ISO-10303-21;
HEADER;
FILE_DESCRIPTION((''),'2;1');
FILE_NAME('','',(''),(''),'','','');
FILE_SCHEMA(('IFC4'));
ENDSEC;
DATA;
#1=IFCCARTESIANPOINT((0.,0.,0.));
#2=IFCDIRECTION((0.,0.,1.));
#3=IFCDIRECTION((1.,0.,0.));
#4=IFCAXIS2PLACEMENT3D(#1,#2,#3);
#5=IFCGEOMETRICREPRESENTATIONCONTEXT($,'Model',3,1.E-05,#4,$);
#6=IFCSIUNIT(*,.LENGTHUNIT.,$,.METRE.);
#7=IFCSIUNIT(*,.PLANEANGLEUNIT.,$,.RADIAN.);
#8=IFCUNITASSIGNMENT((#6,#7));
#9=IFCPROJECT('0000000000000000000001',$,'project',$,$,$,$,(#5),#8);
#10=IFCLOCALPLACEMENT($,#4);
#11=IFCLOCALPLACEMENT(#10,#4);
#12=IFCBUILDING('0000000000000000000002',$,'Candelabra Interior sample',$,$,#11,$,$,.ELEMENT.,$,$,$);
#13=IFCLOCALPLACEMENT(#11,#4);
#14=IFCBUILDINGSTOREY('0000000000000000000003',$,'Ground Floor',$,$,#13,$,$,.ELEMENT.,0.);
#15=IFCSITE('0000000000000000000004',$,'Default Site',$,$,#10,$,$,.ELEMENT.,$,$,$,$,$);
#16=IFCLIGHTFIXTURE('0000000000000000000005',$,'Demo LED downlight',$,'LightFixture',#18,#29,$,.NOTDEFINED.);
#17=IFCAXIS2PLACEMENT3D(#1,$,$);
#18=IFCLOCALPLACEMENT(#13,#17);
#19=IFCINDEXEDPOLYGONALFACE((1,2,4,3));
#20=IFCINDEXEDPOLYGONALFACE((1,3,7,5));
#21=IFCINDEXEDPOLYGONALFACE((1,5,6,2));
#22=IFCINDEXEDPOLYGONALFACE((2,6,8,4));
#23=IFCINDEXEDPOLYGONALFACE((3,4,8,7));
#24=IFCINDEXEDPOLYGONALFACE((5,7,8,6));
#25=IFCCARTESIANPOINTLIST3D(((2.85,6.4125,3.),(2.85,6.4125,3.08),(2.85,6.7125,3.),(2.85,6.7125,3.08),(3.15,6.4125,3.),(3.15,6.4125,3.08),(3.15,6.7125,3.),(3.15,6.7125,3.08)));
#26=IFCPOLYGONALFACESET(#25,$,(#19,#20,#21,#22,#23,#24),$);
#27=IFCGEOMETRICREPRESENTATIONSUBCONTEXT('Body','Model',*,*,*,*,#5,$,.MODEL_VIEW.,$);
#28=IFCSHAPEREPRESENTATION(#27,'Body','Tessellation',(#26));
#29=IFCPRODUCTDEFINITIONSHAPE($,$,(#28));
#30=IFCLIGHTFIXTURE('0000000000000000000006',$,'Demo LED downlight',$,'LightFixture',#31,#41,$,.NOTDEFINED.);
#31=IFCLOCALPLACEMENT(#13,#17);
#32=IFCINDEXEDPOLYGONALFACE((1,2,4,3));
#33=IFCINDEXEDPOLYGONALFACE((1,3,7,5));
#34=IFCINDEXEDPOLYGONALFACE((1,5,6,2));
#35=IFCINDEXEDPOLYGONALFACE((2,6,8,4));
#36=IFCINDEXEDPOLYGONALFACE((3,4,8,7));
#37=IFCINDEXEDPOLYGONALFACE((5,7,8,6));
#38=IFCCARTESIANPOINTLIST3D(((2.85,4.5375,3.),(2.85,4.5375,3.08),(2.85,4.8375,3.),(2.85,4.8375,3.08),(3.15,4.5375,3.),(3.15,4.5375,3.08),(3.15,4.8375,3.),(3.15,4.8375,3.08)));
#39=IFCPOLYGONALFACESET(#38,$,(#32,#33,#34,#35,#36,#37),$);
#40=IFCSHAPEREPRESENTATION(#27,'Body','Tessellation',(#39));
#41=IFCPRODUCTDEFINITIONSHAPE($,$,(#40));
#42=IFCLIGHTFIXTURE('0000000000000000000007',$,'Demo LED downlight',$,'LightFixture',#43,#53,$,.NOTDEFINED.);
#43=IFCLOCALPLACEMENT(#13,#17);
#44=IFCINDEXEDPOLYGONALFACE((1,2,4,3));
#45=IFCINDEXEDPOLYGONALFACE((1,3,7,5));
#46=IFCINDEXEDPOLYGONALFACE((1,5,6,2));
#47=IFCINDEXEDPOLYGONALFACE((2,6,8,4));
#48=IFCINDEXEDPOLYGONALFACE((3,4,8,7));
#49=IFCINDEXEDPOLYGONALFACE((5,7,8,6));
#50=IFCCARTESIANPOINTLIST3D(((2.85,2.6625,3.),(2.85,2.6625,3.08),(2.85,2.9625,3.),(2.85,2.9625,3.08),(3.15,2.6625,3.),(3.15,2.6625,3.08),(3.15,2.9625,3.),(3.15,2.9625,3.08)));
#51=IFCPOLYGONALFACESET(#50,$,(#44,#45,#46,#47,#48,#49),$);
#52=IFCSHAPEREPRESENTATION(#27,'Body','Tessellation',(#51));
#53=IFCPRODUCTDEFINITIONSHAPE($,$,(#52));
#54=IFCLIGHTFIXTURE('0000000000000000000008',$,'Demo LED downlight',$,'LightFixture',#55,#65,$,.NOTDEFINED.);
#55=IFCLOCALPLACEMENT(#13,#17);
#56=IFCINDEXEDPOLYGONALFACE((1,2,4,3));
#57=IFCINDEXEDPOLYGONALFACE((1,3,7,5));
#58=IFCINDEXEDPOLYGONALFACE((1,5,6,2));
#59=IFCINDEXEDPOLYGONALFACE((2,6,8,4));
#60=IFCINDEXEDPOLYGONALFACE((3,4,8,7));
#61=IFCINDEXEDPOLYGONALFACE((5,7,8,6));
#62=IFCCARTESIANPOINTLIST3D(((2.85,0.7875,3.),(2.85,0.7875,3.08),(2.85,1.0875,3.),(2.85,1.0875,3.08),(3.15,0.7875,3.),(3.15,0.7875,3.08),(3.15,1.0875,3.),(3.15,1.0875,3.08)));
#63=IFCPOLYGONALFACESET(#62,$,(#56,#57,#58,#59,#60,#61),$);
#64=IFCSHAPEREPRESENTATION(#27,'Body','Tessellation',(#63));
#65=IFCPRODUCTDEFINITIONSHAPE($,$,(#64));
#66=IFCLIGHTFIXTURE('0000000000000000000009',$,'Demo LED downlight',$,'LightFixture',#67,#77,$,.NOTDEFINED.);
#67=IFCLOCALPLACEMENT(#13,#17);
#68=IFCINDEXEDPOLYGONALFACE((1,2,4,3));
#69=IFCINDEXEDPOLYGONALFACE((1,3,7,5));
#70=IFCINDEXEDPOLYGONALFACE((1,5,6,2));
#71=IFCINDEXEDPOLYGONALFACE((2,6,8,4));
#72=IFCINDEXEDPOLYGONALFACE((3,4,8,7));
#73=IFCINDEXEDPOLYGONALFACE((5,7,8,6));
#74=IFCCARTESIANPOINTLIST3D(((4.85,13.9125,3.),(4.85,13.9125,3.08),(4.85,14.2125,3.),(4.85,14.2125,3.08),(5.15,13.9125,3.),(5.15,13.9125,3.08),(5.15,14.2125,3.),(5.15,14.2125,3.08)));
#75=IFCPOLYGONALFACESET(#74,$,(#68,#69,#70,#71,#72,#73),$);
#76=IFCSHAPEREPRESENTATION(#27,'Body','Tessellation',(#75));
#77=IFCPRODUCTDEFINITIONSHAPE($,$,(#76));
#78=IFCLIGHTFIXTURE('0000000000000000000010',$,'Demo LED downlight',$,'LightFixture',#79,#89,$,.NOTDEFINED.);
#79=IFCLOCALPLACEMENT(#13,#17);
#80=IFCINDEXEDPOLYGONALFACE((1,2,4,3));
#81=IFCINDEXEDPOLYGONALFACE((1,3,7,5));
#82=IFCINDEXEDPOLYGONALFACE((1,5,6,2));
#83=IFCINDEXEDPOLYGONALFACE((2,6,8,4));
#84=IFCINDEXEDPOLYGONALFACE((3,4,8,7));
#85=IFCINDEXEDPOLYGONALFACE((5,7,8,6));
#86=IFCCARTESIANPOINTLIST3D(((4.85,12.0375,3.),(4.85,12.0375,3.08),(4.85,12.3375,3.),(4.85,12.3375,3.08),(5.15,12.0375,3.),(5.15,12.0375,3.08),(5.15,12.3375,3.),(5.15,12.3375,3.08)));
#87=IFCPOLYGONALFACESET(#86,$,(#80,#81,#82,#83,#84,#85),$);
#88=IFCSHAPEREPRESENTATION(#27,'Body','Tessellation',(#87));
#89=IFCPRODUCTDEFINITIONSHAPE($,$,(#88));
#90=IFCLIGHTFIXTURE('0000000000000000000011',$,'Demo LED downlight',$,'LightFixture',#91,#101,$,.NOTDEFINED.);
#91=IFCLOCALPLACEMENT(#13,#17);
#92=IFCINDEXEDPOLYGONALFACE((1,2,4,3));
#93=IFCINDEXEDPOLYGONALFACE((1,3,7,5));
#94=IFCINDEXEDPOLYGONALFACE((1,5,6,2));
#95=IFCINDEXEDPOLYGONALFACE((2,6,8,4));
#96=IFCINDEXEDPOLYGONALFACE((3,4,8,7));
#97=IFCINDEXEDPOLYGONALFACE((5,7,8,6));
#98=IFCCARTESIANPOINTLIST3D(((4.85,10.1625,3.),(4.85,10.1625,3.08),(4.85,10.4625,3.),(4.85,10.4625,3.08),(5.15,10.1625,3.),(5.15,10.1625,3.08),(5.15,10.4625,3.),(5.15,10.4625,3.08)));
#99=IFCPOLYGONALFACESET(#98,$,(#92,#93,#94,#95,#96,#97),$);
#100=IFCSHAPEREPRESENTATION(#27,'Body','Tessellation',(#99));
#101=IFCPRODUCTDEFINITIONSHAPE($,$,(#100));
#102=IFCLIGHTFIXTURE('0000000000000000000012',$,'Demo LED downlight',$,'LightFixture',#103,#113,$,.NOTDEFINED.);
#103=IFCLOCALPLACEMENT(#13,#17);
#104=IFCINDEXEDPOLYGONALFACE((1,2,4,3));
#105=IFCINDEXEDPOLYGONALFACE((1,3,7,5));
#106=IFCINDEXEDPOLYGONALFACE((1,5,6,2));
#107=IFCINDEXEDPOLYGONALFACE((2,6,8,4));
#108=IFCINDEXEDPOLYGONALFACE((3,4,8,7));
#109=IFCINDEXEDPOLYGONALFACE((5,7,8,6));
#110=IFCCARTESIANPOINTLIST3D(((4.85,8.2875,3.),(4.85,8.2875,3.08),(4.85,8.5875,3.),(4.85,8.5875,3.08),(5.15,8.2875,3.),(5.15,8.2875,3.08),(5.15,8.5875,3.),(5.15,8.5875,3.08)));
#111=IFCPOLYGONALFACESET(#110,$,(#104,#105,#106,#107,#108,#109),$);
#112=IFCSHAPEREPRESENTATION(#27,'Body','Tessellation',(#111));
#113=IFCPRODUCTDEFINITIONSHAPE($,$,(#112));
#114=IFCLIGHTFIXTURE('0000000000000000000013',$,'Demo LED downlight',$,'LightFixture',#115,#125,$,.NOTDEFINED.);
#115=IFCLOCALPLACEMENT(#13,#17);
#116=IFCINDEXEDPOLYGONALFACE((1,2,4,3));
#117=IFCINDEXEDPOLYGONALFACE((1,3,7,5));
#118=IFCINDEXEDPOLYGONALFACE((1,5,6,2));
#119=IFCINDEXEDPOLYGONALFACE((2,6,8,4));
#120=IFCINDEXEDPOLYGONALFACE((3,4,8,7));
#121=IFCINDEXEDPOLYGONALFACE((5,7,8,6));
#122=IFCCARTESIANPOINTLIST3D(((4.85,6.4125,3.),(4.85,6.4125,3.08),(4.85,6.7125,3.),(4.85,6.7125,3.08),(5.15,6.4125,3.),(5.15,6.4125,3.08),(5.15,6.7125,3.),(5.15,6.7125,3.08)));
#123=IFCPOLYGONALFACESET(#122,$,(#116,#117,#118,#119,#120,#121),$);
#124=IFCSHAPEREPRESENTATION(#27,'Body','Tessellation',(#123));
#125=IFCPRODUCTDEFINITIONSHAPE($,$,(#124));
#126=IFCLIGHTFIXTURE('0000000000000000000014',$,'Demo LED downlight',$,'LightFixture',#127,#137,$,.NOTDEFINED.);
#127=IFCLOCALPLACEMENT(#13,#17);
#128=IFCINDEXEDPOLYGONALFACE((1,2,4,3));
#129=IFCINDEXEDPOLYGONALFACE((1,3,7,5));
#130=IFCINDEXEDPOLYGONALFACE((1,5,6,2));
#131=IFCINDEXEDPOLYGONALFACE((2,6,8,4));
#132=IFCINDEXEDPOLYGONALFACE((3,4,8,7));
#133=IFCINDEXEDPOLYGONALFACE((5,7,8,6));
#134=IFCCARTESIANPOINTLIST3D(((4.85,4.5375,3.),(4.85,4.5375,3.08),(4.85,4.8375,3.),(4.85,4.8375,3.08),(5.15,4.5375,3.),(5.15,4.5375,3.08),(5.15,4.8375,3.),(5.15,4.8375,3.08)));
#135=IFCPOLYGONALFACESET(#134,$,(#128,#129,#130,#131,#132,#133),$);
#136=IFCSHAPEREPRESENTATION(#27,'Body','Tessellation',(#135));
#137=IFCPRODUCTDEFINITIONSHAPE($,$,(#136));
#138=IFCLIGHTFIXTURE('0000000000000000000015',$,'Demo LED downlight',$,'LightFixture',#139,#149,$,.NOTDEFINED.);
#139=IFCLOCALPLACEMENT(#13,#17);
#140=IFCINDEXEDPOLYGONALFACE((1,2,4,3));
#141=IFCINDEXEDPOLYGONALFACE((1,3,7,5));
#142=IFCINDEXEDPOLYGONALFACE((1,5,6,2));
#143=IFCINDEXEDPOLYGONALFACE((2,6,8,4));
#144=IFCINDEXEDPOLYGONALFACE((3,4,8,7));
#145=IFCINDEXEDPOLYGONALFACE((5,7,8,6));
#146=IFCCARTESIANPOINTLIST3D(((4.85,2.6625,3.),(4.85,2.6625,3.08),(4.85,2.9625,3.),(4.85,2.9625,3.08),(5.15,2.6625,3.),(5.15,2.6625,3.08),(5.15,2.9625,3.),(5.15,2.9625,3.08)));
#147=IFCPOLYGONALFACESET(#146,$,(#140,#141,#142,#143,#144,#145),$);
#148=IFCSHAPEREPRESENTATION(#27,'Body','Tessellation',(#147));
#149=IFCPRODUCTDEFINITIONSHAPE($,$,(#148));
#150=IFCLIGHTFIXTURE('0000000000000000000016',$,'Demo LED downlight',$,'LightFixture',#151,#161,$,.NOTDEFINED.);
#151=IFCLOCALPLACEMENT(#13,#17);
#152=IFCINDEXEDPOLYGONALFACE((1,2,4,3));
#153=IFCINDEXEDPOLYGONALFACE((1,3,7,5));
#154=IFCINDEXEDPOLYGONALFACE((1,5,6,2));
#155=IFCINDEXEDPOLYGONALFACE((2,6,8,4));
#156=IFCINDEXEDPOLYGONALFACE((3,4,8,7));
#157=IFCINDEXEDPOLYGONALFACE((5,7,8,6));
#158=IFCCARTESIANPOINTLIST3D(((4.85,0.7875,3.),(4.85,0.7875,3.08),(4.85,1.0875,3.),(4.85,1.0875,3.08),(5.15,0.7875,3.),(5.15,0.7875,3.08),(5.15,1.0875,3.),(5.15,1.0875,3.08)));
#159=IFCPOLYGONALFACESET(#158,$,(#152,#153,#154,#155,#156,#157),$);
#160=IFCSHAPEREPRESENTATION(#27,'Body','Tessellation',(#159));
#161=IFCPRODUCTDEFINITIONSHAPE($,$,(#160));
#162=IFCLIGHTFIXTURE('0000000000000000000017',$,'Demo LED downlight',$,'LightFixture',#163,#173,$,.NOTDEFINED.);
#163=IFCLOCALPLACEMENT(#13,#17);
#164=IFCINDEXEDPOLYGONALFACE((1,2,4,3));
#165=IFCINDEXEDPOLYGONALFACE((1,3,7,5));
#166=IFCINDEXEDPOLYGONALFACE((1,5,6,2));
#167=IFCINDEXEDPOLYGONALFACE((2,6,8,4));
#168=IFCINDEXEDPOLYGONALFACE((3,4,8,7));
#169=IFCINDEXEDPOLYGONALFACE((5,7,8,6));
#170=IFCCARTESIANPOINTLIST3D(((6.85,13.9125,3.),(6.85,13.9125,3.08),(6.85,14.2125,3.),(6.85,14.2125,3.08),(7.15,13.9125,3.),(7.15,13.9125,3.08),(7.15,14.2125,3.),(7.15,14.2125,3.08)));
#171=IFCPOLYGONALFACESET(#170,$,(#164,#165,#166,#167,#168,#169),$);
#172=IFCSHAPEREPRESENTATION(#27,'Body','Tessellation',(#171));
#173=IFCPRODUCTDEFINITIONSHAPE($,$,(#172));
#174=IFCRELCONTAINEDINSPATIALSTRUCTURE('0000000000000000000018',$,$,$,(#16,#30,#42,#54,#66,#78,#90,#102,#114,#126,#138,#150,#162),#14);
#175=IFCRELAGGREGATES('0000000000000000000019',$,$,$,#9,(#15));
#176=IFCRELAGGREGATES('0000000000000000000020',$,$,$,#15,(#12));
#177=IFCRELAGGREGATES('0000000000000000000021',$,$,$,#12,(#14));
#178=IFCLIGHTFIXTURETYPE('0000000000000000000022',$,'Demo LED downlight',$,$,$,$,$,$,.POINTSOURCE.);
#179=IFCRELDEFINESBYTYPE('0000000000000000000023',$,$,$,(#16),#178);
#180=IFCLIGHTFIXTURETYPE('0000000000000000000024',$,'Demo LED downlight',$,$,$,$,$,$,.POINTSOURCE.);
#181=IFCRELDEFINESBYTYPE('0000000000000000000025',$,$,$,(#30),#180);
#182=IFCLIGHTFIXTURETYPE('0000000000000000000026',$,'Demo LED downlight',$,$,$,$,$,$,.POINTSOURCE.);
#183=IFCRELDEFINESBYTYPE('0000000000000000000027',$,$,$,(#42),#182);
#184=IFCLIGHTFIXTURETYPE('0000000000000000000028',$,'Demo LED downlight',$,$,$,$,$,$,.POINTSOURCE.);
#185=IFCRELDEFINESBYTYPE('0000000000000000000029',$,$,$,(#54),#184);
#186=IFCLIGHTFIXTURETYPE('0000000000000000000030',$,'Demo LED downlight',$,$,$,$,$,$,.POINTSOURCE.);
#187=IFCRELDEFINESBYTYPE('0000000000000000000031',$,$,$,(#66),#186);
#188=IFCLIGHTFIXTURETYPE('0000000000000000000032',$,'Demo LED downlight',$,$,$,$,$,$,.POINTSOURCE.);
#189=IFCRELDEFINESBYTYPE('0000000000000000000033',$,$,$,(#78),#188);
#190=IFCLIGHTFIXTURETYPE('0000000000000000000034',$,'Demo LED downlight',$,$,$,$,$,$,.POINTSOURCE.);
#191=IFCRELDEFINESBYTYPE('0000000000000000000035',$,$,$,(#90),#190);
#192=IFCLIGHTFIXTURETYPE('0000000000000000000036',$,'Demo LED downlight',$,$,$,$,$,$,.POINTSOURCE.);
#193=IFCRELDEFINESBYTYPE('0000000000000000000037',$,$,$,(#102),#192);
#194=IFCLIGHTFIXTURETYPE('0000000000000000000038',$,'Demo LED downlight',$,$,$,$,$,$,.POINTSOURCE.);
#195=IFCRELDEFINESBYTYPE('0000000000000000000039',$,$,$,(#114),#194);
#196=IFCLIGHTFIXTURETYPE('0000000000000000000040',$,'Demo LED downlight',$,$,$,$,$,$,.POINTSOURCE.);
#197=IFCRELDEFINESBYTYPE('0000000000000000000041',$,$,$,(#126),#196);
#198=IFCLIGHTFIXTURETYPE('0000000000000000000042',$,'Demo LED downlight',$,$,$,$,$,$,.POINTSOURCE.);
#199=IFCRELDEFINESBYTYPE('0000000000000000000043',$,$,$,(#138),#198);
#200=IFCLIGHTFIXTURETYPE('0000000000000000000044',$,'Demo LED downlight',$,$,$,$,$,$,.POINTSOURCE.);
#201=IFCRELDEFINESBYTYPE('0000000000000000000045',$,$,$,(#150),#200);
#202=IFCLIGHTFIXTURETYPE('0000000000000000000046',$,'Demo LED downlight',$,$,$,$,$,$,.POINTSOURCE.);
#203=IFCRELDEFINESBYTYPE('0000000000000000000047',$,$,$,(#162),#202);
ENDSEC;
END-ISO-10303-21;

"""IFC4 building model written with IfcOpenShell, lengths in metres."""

from ifc_helpers import new_model, si_unit, frame, origin_with_axes, place, context, subcontext, project, spatial, polyline, outline, extrude, type_object, element, save


model = new_model("IFC4")

# Units and contexts
model_context = context("Model", 3, precision=1e-05, world=origin_with_axes())
body_context = subcontext(model_context, "Body", "Model", "MODEL_VIEW")
ifc_project = project(units=[si_unit("LENGTHUNIT", "METRE"), si_unit("PLANEANGLEUNIT", "RADIAN")], contexts=[model_context])

# Site, building, storey
site_placement = place(None, origin_with_axes())
site = spatial("IfcSite", under=ifc_project, at=site_placement, Name="Default Site", CompositionType="ELEMENT")
building_placement = place(site_placement, origin_with_axes())
building = spatial("IfcBuilding", under=site, at=building_placement, Name="Candelabra Interior sample", CompositionType="ELEMENT")
storey_placement = place(building_placement, origin_with_axes())
storey = spatial("IfcBuildingStorey", under=building, at=storey_placement, Name="Ground Floor", CompositionType="ELEMENT", Elevation=0.0)

# Light fixtures
light_fixture_type_1 = type_object("IfcLightFixtureType", Name="Demo LED downlight", PredefinedType="POINTSOURCE")
light_fixture_1_placement = place(storey_placement, frame((3.0, 6.5625, 3.08), z_axis=(0.0, 0.0, 1.0), x_axis=(1.0, 0.0, 0.0)))
element("IfcLightFixture", 1, at=light_fixture_1_placement, inside=storey, type_object=light_fixture_type_1, Name="Demo LED downlight", ObjectType="LightFixture", PredefinedType="NOTDEFINED", context=body_context, shape_type="SweptSolid", body=[
    extrude(outline(polyline([(0.15, 0.15), (-0.15, 0.15), (-0.15, -0.15), (0.15, -0.15), (0.15, 0.15)])), origin_with_axes(), (0.0, 0.0, -1.0), 0.08),
])
light_fixture_type_2 = type_object("IfcLightFixtureType", Name="Demo LED downlight", PredefinedType="POINTSOURCE")
light_fixture_2_placement = place(storey_placement, frame((3.0, 4.6875, 3.08), z_axis=(0.0, 0.0, 1.0), x_axis=(1.0, 0.0, 0.0)))
element("IfcLightFixture", 2, at=light_fixture_2_placement, inside=storey, type_object=light_fixture_type_2, Name="Demo LED downlight", ObjectType="LightFixture", PredefinedType="NOTDEFINED", context=body_context, shape_type="SweptSolid", body=[
    extrude(outline(polyline([(0.15, 0.15), (-0.15, 0.15), (-0.15, -0.15), (0.15, -0.15), (0.15, 0.15)])), origin_with_axes(), (0.0, 0.0, -1.0), 0.08),
])
light_fixture_type_3 = type_object("IfcLightFixtureType", Name="Demo LED downlight", PredefinedType="POINTSOURCE")
light_fixture_3_placement = place(storey_placement, frame((3.0, 2.8125, 3.08), z_axis=(0.0, 0.0, 1.0), x_axis=(1.0, 0.0, 0.0)))
element("IfcLightFixture", 3, at=light_fixture_3_placement, inside=storey, type_object=light_fixture_type_3, Name="Demo LED downlight", ObjectType="LightFixture", PredefinedType="NOTDEFINED", context=body_context, shape_type="SweptSolid", body=[
    extrude(outline(polyline([(0.15, 0.15), (-0.15, 0.15), (-0.15, -0.15), (0.15, -0.15), (0.15, 0.15)])), origin_with_axes(), (0.0, 0.0, -1.0), 0.08),
])
light_fixture_type_4 = type_object("IfcLightFixtureType", Name="Demo LED downlight", PredefinedType="POINTSOURCE")
light_fixture_4_placement = place(storey_placement, frame((3.0, 0.9375, 3.08), z_axis=(0.0, 0.0, 1.0), x_axis=(1.0, 0.0, 0.0)))
element("IfcLightFixture", 4, at=light_fixture_4_placement, inside=storey, type_object=light_fixture_type_4, Name="Demo LED downlight", ObjectType="LightFixture", PredefinedType="NOTDEFINED", context=body_context, shape_type="SweptSolid", body=[
    extrude(outline(polyline([(0.15, 0.15), (-0.15, 0.15), (-0.15, -0.15), (0.15, -0.15), (0.15, 0.15)])), origin_with_axes(), (0.0, 0.0, -1.0), 0.08),
])
light_fixture_type_5 = type_object("IfcLightFixtureType", Name="Demo LED downlight", PredefinedType="POINTSOURCE")
light_fixture_5_placement = place(storey_placement, frame((5.0, 14.0625, 3.08), z_axis=(0.0, 0.0, 1.0), x_axis=(1.0, 0.0, 0.0)))
element("IfcLightFixture", 5, at=light_fixture_5_placement, inside=storey, type_object=light_fixture_type_5, Name="Demo LED downlight", ObjectType="LightFixture", PredefinedType="NOTDEFINED", context=body_context, shape_type="SweptSolid", body=[
    extrude(outline(polyline([(0.15, 0.15), (-0.15, 0.15), (-0.15, -0.15), (0.15, -0.15), (0.15, 0.15)])), origin_with_axes(), (0.0, 0.0, -1.0), 0.08),
])
light_fixture_type_6 = type_object("IfcLightFixtureType", Name="Demo LED downlight", PredefinedType="POINTSOURCE")
light_fixture_6_placement = place(storey_placement, frame((5.0, 12.1875, 3.08), z_axis=(0.0, 0.0, 1.0), x_axis=(1.0, 0.0, 0.0)))
element("IfcLightFixture", 6, at=light_fixture_6_placement, inside=storey, type_object=light_fixture_type_6, Name="Demo LED downlight", ObjectType="LightFixture", PredefinedType="NOTDEFINED", context=body_context, shape_type="SweptSolid", body=[
    extrude(outline(polyline([(0.15, 0.15), (-0.15, 0.15), (-0.15, -0.15), (0.15, -0.15), (0.15, 0.15)])), origin_with_axes(), (0.0, 0.0, -1.0), 0.08),
])
light_fixture_type_7 = type_object("IfcLightFixtureType", Name="Demo LED downlight", PredefinedType="POINTSOURCE")
light_fixture_7_placement = place(storey_placement, frame((5.0, 10.3125, 3.08), z_axis=(0.0, 0.0, 1.0), x_axis=(1.0, 0.0, 0.0)))
element("IfcLightFixture", 7, at=light_fixture_7_placement, inside=storey, type_object=light_fixture_type_7, Name="Demo LED downlight", ObjectType="LightFixture", PredefinedType="NOTDEFINED", context=body_context, shape_type="SweptSolid", body=[
    extrude(outline(polyline([(0.15, 0.15), (-0.15, 0.15), (-0.15, -0.15), (0.15, -0.15), (0.15, 0.15)])), origin_with_axes(), (0.0, 0.0, -1.0), 0.08),
])
light_fixture_type_8 = type_object("IfcLightFixtureType", Name="Demo LED downlight", PredefinedType="POINTSOURCE")
light_fixture_8_placement = place(storey_placement, frame((5.0, 8.4375, 3.08), z_axis=(0.0, 0.0, 1.0), x_axis=(1.0, 0.0, 0.0)))
element("IfcLightFixture", 8, at=light_fixture_8_placement, inside=storey, type_object=light_fixture_type_8, Name="Demo LED downlight", ObjectType="LightFixture", PredefinedType="NOTDEFINED", context=body_context, shape_type="SweptSolid", body=[
    extrude(outline(polyline([(0.15, 0.15), (-0.15, 0.15), (-0.15, -0.15), (0.15, -0.15), (0.15, 0.15)])), origin_with_axes(), (0.0, 0.0, -1.0), 0.08),
])
light_fixture_type_9 = type_object("IfcLightFixtureType", Name="Demo LED downlight", PredefinedType="POINTSOURCE")
light_fixture_9_placement = place(storey_placement, frame((5.0, 6.5625, 3.08), z_axis=(0.0, 0.0, 1.0), x_axis=(1.0, 0.0, 0.0)))
element("IfcLightFixture", 9, at=light_fixture_9_placement, inside=storey, type_object=light_fixture_type_9, Name="Demo LED downlight", ObjectType="LightFixture", PredefinedType="NOTDEFINED", context=body_context, shape_type="SweptSolid", body=[
    extrude(outline(polyline([(0.15, 0.15), (-0.15, 0.15), (-0.15, -0.15), (0.15, -0.15), (0.15, 0.15)])), origin_with_axes(), (0.0, 0.0, -1.0), 0.08),
])
light_fixture_type_10 = type_object("IfcLightFixtureType", Name="Demo LED downlight", PredefinedType="POINTSOURCE")
light_fixture_10_placement = place(storey_placement, frame((5.0, 4.6875, 3.08), z_axis=(0.0, 0.0, 1.0), x_axis=(1.0, 0.0, 0.0)))
element("IfcLightFixture", 10, at=light_fixture_10_placement, inside=storey, type_object=light_fixture_type_10, Name="Demo LED downlight", ObjectType="LightFixture", PredefinedType="NOTDEFINED", context=body_context, shape_type="SweptSolid", body=[
    extrude(outline(polyline([(0.15, 0.15), (-0.15, 0.15), (-0.15, -0.15), (0.15, -0.15), (0.15, 0.15)])), origin_with_axes(), (0.0, 0.0, -1.0), 0.08),
])
light_fixture_type_11 = type_object("IfcLightFixtureType", Name="Demo LED downlight", PredefinedType="POINTSOURCE")
light_fixture_11_placement = place(storey_placement, frame((5.0, 2.8125, 3.08), z_axis=(0.0, 0.0, 1.0), x_axis=(1.0, 0.0, 0.0)))
element("IfcLightFixture", 11, at=light_fixture_11_placement, inside=storey, type_object=light_fixture_type_11, Name="Demo LED downlight", ObjectType="LightFixture", PredefinedType="NOTDEFINED", context=body_context, shape_type="SweptSolid", body=[
    extrude(outline(polyline([(0.15, 0.15), (-0.15, 0.15), (-0.15, -0.15), (0.15, -0.15), (0.15, 0.15)])), origin_with_axes(), (0.0, 0.0, -1.0), 0.08),
])
light_fixture_type_12 = type_object("IfcLightFixtureType", Name="Demo LED downlight", PredefinedType="POINTSOURCE")
light_fixture_12_placement = place(storey_placement, frame((5.0, 0.9375, 3.08), z_axis=(0.0, 0.0, 1.0), x_axis=(1.0, 0.0, 0.0)))
element("IfcLightFixture", 12, at=light_fixture_12_placement, inside=storey, type_object=light_fixture_type_12, Name="Demo LED downlight", ObjectType="LightFixture", PredefinedType="NOTDEFINED", context=body_context, shape_type="SweptSolid", body=[
    extrude(outline(polyline([(0.15, 0.15), (-0.15, 0.15), (-0.15, -0.15), (0.15, -0.15), (0.15, 0.15)])), origin_with_axes(), (0.0, 0.0, -1.0), 0.08),
])
light_fixture_type_13 = type_object("IfcLightFixtureType", Name="Demo LED downlight", PredefinedType="POINTSOURCE")
light_fixture_13_placement = place(storey_placement, frame((7.0, 14.0625, 3.08), z_axis=(0.0, 0.0, 1.0), x_axis=(1.0, 0.0, 0.0)))
element("IfcLightFixture", 13, at=light_fixture_13_placement, inside=storey, type_object=light_fixture_type_13, Name="Demo LED downlight", ObjectType="LightFixture", PredefinedType="NOTDEFINED", context=body_context, shape_type="SweptSolid", body=[
    extrude(outline(polyline([(0.15, 0.15), (-0.15, 0.15), (-0.15, -0.15), (0.15, -0.15), (0.15, 0.15)])), origin_with_axes(), (0.0, 0.0, -1.0), 0.08),
])

save(model, "model.ifc")
